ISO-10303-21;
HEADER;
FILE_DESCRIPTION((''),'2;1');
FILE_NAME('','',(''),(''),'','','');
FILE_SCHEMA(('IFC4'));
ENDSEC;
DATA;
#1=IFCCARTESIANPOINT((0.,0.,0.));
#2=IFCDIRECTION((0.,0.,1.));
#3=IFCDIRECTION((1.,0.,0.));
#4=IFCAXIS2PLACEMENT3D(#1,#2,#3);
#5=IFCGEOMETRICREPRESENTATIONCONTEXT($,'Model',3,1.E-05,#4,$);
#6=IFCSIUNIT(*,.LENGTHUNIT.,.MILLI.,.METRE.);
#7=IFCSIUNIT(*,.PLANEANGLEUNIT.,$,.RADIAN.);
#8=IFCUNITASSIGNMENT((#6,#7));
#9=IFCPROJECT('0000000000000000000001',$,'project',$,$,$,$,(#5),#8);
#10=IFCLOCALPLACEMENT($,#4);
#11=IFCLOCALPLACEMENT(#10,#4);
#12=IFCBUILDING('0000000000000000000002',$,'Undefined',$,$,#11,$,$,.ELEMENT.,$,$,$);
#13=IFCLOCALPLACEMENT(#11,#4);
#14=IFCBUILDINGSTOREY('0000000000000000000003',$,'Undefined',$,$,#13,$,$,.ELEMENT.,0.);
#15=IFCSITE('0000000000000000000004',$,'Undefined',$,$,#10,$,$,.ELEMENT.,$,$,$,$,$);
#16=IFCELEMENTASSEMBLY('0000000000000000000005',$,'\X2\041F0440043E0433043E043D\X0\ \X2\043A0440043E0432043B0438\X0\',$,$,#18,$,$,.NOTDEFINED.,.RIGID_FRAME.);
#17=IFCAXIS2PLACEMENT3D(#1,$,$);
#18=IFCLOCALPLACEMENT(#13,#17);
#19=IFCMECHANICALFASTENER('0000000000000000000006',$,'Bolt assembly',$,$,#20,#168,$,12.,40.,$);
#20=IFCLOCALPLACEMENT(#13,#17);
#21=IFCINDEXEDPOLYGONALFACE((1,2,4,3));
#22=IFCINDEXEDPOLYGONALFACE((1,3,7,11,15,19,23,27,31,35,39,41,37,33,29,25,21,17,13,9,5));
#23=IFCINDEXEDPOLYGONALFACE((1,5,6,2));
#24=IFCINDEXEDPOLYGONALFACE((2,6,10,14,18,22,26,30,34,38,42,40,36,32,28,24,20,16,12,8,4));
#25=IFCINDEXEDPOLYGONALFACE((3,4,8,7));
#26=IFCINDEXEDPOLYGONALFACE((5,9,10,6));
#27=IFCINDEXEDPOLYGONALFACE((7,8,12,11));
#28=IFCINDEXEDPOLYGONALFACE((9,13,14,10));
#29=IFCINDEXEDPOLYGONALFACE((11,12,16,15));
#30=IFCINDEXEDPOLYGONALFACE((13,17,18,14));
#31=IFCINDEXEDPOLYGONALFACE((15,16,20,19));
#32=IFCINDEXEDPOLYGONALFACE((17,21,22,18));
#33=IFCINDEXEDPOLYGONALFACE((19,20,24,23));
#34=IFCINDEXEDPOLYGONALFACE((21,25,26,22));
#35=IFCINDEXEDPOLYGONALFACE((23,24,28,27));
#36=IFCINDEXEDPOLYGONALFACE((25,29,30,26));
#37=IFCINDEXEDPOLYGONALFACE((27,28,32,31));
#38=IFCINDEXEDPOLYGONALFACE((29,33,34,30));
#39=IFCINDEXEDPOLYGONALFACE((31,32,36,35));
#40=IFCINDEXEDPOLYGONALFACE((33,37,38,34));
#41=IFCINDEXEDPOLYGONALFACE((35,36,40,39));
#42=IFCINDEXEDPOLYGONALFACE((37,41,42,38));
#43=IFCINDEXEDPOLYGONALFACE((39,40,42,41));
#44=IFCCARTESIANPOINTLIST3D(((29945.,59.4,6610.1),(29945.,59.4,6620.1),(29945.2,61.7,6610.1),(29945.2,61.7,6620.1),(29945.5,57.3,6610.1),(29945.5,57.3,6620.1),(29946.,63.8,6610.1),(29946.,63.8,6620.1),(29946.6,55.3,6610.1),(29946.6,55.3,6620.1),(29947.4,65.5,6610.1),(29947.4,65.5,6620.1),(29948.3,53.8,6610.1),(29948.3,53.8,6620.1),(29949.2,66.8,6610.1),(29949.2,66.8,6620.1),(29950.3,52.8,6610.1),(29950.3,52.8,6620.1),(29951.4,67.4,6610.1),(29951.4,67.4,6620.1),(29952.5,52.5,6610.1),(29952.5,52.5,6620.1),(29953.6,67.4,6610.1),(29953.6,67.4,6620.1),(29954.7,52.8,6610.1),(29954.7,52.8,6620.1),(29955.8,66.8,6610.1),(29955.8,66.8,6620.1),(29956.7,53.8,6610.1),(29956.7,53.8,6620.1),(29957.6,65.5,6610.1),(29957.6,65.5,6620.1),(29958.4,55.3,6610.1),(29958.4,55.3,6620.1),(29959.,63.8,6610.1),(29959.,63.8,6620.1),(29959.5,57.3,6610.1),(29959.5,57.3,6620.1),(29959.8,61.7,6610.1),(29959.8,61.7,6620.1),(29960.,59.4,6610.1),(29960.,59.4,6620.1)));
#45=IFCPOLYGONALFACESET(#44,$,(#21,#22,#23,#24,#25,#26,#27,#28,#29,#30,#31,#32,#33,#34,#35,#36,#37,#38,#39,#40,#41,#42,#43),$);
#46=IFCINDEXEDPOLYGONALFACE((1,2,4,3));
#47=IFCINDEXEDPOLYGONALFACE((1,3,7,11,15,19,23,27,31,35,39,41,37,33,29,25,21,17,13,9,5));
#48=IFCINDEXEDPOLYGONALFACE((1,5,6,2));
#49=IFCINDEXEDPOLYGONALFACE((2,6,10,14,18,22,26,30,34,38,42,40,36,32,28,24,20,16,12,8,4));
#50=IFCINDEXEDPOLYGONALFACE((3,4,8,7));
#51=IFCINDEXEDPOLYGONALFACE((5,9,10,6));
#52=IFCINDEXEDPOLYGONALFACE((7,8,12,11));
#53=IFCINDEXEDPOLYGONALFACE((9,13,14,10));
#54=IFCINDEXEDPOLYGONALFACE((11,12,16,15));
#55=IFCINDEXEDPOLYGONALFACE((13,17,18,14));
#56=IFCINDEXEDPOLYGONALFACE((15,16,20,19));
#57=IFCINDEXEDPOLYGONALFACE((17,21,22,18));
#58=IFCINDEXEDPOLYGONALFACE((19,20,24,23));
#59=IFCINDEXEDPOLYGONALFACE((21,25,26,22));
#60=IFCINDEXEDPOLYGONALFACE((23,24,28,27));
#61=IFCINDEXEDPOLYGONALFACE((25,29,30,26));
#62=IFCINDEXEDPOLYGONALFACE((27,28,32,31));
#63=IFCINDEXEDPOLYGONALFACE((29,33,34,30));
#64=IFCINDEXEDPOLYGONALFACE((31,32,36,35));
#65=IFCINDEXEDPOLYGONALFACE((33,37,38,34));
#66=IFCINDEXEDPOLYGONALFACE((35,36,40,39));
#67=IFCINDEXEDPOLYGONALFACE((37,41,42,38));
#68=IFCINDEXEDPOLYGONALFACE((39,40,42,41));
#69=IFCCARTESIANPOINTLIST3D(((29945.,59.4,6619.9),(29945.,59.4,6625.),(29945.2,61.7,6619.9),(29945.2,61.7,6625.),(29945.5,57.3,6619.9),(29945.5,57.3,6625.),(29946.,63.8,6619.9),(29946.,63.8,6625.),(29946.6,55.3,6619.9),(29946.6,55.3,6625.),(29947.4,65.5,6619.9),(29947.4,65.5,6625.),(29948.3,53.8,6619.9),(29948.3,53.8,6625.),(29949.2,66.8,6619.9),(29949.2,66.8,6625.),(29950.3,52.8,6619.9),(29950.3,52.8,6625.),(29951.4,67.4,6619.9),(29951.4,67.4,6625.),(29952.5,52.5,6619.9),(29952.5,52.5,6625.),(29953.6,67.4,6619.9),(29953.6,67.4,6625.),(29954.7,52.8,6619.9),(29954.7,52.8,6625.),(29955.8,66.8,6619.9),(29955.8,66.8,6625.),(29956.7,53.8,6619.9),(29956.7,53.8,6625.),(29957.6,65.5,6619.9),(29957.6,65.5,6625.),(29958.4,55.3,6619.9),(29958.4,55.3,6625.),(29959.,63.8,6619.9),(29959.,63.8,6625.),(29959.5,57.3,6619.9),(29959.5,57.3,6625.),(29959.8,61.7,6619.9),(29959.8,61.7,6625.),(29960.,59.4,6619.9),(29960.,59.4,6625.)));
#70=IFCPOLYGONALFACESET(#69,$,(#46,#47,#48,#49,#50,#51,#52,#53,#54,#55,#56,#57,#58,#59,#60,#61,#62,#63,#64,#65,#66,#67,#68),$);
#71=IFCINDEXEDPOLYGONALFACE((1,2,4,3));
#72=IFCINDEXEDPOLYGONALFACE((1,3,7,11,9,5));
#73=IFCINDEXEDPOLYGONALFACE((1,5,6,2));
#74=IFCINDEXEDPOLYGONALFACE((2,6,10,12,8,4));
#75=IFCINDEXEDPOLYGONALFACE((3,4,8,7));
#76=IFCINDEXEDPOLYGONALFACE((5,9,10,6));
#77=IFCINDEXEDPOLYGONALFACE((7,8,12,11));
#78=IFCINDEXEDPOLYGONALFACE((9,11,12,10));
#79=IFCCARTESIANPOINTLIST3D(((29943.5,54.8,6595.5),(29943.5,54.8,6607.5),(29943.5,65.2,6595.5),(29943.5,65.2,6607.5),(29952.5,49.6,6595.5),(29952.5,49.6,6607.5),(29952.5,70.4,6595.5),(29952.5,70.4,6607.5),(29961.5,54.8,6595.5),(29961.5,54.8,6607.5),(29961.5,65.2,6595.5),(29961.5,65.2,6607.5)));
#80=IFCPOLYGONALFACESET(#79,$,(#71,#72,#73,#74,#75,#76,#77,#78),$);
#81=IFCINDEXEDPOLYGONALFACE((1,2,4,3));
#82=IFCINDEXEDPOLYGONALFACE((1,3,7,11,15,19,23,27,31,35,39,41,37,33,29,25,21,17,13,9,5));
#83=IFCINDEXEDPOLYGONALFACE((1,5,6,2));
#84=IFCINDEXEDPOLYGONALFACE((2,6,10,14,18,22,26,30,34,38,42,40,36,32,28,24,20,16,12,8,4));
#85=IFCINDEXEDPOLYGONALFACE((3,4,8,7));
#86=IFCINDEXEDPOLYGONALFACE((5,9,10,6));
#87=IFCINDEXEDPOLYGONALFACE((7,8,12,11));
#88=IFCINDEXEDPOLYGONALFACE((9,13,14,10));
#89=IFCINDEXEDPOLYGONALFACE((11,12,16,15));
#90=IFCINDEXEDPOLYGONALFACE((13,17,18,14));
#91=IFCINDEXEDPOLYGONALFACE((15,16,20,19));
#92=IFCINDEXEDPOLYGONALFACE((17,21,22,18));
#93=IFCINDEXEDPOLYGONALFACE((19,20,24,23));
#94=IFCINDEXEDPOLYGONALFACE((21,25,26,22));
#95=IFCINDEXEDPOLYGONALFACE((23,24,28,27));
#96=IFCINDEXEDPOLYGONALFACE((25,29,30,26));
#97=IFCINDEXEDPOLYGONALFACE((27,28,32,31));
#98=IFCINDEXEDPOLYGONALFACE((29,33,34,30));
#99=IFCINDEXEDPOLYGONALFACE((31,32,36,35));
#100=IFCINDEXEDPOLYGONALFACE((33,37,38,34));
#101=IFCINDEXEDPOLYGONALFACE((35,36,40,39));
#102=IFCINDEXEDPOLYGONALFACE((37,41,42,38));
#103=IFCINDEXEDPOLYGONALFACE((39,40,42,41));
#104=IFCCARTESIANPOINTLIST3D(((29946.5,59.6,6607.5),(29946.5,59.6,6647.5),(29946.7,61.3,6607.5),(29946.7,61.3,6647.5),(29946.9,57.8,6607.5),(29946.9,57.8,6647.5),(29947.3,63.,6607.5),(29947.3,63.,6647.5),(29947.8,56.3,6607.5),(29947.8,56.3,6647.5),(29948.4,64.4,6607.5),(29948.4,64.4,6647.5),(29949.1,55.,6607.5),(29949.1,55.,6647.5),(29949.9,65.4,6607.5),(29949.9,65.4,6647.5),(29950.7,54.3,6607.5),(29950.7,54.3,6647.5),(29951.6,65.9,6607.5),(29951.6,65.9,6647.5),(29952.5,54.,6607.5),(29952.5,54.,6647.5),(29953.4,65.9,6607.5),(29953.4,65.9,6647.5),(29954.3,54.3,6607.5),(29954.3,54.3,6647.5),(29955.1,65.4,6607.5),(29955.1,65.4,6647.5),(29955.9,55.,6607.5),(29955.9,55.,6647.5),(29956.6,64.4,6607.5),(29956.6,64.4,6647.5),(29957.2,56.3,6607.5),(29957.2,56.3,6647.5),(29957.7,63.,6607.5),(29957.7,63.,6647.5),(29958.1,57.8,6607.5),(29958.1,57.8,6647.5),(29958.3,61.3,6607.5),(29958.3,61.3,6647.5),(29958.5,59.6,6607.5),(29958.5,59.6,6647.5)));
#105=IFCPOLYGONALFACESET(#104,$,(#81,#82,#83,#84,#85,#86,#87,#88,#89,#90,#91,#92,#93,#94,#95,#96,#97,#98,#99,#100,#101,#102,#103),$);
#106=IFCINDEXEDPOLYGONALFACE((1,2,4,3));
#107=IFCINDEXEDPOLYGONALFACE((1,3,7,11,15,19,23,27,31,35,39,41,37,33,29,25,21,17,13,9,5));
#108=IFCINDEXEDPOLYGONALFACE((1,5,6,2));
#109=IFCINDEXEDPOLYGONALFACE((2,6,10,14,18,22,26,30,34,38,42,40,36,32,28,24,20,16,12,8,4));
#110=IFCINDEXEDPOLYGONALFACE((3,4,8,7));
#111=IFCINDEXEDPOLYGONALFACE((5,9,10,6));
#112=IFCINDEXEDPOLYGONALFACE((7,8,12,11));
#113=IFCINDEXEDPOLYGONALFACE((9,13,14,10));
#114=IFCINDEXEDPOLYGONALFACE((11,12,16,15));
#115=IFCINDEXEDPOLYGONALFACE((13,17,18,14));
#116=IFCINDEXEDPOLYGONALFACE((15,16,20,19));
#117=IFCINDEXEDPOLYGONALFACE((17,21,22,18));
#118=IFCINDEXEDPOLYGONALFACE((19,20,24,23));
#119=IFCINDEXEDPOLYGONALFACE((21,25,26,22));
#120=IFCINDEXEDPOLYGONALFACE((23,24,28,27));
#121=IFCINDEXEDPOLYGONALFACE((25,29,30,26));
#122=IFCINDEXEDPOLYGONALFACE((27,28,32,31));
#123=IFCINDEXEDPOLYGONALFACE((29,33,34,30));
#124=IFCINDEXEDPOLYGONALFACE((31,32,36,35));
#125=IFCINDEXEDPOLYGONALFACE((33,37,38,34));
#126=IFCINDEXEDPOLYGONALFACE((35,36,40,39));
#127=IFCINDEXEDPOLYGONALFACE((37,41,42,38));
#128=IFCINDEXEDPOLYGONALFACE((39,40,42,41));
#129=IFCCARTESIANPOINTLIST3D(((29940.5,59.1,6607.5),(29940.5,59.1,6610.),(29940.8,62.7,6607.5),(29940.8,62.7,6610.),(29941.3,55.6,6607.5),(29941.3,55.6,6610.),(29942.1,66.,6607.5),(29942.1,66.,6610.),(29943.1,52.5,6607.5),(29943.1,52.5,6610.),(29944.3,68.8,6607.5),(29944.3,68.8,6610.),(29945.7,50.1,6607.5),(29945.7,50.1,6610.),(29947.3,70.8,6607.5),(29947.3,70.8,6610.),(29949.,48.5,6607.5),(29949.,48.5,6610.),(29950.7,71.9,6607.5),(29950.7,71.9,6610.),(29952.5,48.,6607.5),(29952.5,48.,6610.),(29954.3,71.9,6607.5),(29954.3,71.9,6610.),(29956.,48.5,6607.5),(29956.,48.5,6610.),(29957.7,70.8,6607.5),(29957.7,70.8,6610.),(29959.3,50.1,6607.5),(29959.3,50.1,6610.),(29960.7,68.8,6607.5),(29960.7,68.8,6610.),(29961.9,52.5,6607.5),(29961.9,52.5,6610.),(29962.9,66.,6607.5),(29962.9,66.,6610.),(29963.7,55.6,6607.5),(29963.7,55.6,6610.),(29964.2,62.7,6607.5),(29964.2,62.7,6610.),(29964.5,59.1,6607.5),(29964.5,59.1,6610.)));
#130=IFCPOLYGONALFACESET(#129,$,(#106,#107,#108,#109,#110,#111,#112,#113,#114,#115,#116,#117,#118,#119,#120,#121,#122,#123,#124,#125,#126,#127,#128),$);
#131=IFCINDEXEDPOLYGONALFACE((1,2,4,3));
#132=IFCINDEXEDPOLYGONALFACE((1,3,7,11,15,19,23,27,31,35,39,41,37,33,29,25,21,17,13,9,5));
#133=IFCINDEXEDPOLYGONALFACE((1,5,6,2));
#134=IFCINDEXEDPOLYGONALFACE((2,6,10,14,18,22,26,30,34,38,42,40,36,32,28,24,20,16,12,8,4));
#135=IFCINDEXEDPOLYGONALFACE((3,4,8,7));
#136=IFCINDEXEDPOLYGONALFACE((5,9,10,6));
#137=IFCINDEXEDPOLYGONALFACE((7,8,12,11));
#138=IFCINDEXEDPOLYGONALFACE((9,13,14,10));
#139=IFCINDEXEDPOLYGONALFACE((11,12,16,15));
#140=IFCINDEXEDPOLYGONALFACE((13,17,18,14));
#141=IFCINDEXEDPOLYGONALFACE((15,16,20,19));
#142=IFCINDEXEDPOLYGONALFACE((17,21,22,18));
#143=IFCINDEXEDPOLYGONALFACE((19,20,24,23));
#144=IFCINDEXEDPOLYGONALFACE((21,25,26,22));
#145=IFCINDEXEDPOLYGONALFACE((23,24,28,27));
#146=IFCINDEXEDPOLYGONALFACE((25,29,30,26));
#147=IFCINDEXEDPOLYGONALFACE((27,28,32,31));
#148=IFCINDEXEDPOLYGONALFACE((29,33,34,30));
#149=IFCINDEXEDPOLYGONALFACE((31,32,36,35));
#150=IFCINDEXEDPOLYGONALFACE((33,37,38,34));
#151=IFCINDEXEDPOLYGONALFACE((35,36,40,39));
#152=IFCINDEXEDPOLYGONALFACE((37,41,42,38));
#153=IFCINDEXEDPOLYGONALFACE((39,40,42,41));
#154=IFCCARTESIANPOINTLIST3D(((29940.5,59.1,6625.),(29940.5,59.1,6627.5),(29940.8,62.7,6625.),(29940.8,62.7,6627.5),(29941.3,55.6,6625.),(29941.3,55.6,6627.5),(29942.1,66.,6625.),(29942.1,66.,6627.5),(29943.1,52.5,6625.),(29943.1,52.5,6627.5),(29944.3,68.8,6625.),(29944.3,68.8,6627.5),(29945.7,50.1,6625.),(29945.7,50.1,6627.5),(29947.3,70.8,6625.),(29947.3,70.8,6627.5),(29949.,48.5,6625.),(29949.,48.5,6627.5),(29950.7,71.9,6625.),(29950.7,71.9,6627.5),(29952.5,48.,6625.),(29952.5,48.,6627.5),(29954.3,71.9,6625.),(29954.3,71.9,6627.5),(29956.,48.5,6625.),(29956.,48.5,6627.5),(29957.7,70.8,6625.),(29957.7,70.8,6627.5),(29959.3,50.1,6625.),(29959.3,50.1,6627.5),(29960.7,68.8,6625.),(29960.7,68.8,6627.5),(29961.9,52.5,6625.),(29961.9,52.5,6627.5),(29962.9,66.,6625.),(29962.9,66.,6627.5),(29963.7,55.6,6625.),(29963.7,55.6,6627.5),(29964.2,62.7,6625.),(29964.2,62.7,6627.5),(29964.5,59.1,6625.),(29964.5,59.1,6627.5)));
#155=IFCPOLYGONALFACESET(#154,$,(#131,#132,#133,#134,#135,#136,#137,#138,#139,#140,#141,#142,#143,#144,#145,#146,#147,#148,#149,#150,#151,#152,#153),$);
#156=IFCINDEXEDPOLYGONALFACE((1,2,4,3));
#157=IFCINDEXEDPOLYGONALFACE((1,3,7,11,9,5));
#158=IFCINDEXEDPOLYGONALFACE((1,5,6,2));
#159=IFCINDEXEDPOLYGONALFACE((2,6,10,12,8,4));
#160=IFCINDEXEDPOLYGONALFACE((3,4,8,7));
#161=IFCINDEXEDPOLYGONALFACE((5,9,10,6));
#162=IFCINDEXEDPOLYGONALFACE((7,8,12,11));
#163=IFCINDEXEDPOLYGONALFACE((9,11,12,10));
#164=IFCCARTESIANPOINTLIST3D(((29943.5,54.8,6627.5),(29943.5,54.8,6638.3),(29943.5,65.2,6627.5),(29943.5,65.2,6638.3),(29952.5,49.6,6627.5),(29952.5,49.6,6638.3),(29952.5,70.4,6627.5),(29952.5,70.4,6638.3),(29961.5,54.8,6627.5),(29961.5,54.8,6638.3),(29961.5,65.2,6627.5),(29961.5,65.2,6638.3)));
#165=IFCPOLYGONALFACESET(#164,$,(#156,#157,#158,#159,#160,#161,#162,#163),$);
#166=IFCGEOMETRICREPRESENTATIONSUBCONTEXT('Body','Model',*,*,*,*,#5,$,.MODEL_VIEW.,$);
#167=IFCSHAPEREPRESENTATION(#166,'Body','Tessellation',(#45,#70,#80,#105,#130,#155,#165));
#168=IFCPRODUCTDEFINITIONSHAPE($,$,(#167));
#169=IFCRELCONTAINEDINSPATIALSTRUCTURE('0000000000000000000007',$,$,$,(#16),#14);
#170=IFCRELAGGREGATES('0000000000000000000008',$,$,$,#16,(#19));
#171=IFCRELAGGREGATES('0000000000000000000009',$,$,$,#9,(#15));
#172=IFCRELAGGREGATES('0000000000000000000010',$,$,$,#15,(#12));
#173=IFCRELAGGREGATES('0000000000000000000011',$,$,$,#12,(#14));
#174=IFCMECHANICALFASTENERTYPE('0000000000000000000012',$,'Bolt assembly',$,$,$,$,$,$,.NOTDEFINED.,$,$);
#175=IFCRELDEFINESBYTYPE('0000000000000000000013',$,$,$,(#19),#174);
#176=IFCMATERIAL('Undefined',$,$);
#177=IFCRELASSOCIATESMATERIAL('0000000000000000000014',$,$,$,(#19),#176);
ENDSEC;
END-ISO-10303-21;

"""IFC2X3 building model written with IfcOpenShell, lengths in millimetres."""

from ifc_helpers import new_model, si_unit, frame, origin_with_axes, origin_2d_with_axis, place, context, subcontext, project, spatial, polyline, circle, outline, extrude, source, transform, mapped, material, type_object, element, aggregate, save


model = new_model("IFC2X3")

# Units and contexts
model_context = context("Model", 3, precision=1e-05, world=origin_with_axes())
body_context = subcontext(model_context, "Body", "Model", "MODEL_VIEW")
ifc_project = project(units=[si_unit("LENGTHUNIT", "METRE", prefix="MILLI"), si_unit("PLANEANGLEUNIT", "RADIAN")], contexts=[model_context])

# Site, building, storey
site_placement = place(None, origin_with_axes())
site = spatial("IfcSite", under=ifc_project, at=site_placement, Name="Undefined", CompositionType="ELEMENT")
building_placement = place(site_placement, origin_with_axes())
building = spatial("IfcBuilding", under=site, at=building_placement, Name="Undefined", CompositionType="ELEMENT")
storey_placement = place(building_placement, origin_with_axes())
storey = spatial("IfcBuildingStorey", under=building, at=storey_placement, Name="Undefined", CompositionType="ELEMENT", Elevation=0.0)

# Element assembly
assembly_1_placement = place(storey_placement, origin_with_axes())
assembly_1 = element("IfcElementAssembly", 1, at=assembly_1_placement, inside=storey, Name="Прогон кровли", AssemblyPlace="NOTDEFINED", PredefinedType="RIGID_FRAME")

# Mechanical fastener
ifc_material_1 = material(Name="Undefined")
mechanical_fastener_type = type_object("IfcMechanicalFastenerType", Name="Bolt assembly")
shared_shape_1 = source(origin_with_axes(), body_context, "Body", "SweptSolid", [
    extrude(circle(Radius=7.5, at=origin_2d_with_axis()), frame((0.0, -9.9, 0.0), z_axis=(0.0, 1.0, 0.0), x_axis=(1.0, 0.0, 0.0)), (0.0, 0.0, 1.0), 10.0),
    extrude(circle(Radius=7.5, at=origin_2d_with_axis()), frame((0.0, -0.1, 0.0), z_axis=(0.0, 1.0, 0.0), x_axis=(1.0, 0.0, 0.0)), (0.0, 0.0, 1.0), 5.1),
    extrude(outline(polyline([(10.4, 0.0), (5.2, 9.0), (-5.2, 9.0), (-10.4, 0.0), (-5.2, -9.0), (5.2, -9.0), (10.4, 0.0)])), frame((0.0, -24.5, 0.0), z_axis=(0.0, 1.0, 0.0), x_axis=(1.0, 0.0, 0.0)), (0.0, 0.0, 1.0), 12.0),
    extrude(circle(Radius=6.0, at=origin_2d_with_axis()), frame((0.0, -12.5, 0.0), z_axis=(0.0, 1.0, 0.0), x_axis=(1.0, 0.0, 0.0)), (0.0, 0.0, 1.0), 40.0),
    extrude(circle(Radius=12.0, at=origin_2d_with_axis()), frame((0.0, -12.5, 0.0), z_axis=(0.0, 1.0, 0.0), x_axis=(1.0, 0.0, 0.0)), (0.0, 0.0, 1.0), 2.5),
    extrude(circle(Radius=12.0, at=origin_2d_with_axis()), frame((0.0, 5.0, 0.0), z_axis=(0.0, 1.0, 0.0), x_axis=(1.0, 0.0, 0.0)), (0.0, 0.0, 1.0), 2.5),
    extrude(outline(polyline([(10.4, 0.0), (5.2, 9.0), (-5.2, 9.0), (-10.4, 0.0), (-5.2, -9.0), (5.2, -9.0), (10.4, 0.0)])), frame((0.0, 7.5, 0.0), z_axis=(0.0, 1.0, 0.0), x_axis=(1.0, 0.0, 0.0)), (0.0, 0.0, 1.0), 10.8),
])
mechanical_fastener_1_placement = place(assembly_1_placement, frame((29952.5, 60.0, 6620.0), z_axis=(-1.0, 0.0, 0.0), x_axis=(0.0, -1.0, 0.0)))
mechanical_fastener_1 = element("IfcMechanicalFastener", 2, at=mechanical_fastener_1_placement, type_object=mechanical_fastener_type, material=ifc_material_1, Name="Bolt assembly", NominalDiameter=12.0, NominalLength=40.0, context=body_context, shape_type="MappedRepresentation", body=[
    mapped(shared_shape_1, transform((0.0, 0.0, 0.0))),
])
aggregate(assembly_1, [mechanical_fastener_1])

save(model, "model.ifc")
